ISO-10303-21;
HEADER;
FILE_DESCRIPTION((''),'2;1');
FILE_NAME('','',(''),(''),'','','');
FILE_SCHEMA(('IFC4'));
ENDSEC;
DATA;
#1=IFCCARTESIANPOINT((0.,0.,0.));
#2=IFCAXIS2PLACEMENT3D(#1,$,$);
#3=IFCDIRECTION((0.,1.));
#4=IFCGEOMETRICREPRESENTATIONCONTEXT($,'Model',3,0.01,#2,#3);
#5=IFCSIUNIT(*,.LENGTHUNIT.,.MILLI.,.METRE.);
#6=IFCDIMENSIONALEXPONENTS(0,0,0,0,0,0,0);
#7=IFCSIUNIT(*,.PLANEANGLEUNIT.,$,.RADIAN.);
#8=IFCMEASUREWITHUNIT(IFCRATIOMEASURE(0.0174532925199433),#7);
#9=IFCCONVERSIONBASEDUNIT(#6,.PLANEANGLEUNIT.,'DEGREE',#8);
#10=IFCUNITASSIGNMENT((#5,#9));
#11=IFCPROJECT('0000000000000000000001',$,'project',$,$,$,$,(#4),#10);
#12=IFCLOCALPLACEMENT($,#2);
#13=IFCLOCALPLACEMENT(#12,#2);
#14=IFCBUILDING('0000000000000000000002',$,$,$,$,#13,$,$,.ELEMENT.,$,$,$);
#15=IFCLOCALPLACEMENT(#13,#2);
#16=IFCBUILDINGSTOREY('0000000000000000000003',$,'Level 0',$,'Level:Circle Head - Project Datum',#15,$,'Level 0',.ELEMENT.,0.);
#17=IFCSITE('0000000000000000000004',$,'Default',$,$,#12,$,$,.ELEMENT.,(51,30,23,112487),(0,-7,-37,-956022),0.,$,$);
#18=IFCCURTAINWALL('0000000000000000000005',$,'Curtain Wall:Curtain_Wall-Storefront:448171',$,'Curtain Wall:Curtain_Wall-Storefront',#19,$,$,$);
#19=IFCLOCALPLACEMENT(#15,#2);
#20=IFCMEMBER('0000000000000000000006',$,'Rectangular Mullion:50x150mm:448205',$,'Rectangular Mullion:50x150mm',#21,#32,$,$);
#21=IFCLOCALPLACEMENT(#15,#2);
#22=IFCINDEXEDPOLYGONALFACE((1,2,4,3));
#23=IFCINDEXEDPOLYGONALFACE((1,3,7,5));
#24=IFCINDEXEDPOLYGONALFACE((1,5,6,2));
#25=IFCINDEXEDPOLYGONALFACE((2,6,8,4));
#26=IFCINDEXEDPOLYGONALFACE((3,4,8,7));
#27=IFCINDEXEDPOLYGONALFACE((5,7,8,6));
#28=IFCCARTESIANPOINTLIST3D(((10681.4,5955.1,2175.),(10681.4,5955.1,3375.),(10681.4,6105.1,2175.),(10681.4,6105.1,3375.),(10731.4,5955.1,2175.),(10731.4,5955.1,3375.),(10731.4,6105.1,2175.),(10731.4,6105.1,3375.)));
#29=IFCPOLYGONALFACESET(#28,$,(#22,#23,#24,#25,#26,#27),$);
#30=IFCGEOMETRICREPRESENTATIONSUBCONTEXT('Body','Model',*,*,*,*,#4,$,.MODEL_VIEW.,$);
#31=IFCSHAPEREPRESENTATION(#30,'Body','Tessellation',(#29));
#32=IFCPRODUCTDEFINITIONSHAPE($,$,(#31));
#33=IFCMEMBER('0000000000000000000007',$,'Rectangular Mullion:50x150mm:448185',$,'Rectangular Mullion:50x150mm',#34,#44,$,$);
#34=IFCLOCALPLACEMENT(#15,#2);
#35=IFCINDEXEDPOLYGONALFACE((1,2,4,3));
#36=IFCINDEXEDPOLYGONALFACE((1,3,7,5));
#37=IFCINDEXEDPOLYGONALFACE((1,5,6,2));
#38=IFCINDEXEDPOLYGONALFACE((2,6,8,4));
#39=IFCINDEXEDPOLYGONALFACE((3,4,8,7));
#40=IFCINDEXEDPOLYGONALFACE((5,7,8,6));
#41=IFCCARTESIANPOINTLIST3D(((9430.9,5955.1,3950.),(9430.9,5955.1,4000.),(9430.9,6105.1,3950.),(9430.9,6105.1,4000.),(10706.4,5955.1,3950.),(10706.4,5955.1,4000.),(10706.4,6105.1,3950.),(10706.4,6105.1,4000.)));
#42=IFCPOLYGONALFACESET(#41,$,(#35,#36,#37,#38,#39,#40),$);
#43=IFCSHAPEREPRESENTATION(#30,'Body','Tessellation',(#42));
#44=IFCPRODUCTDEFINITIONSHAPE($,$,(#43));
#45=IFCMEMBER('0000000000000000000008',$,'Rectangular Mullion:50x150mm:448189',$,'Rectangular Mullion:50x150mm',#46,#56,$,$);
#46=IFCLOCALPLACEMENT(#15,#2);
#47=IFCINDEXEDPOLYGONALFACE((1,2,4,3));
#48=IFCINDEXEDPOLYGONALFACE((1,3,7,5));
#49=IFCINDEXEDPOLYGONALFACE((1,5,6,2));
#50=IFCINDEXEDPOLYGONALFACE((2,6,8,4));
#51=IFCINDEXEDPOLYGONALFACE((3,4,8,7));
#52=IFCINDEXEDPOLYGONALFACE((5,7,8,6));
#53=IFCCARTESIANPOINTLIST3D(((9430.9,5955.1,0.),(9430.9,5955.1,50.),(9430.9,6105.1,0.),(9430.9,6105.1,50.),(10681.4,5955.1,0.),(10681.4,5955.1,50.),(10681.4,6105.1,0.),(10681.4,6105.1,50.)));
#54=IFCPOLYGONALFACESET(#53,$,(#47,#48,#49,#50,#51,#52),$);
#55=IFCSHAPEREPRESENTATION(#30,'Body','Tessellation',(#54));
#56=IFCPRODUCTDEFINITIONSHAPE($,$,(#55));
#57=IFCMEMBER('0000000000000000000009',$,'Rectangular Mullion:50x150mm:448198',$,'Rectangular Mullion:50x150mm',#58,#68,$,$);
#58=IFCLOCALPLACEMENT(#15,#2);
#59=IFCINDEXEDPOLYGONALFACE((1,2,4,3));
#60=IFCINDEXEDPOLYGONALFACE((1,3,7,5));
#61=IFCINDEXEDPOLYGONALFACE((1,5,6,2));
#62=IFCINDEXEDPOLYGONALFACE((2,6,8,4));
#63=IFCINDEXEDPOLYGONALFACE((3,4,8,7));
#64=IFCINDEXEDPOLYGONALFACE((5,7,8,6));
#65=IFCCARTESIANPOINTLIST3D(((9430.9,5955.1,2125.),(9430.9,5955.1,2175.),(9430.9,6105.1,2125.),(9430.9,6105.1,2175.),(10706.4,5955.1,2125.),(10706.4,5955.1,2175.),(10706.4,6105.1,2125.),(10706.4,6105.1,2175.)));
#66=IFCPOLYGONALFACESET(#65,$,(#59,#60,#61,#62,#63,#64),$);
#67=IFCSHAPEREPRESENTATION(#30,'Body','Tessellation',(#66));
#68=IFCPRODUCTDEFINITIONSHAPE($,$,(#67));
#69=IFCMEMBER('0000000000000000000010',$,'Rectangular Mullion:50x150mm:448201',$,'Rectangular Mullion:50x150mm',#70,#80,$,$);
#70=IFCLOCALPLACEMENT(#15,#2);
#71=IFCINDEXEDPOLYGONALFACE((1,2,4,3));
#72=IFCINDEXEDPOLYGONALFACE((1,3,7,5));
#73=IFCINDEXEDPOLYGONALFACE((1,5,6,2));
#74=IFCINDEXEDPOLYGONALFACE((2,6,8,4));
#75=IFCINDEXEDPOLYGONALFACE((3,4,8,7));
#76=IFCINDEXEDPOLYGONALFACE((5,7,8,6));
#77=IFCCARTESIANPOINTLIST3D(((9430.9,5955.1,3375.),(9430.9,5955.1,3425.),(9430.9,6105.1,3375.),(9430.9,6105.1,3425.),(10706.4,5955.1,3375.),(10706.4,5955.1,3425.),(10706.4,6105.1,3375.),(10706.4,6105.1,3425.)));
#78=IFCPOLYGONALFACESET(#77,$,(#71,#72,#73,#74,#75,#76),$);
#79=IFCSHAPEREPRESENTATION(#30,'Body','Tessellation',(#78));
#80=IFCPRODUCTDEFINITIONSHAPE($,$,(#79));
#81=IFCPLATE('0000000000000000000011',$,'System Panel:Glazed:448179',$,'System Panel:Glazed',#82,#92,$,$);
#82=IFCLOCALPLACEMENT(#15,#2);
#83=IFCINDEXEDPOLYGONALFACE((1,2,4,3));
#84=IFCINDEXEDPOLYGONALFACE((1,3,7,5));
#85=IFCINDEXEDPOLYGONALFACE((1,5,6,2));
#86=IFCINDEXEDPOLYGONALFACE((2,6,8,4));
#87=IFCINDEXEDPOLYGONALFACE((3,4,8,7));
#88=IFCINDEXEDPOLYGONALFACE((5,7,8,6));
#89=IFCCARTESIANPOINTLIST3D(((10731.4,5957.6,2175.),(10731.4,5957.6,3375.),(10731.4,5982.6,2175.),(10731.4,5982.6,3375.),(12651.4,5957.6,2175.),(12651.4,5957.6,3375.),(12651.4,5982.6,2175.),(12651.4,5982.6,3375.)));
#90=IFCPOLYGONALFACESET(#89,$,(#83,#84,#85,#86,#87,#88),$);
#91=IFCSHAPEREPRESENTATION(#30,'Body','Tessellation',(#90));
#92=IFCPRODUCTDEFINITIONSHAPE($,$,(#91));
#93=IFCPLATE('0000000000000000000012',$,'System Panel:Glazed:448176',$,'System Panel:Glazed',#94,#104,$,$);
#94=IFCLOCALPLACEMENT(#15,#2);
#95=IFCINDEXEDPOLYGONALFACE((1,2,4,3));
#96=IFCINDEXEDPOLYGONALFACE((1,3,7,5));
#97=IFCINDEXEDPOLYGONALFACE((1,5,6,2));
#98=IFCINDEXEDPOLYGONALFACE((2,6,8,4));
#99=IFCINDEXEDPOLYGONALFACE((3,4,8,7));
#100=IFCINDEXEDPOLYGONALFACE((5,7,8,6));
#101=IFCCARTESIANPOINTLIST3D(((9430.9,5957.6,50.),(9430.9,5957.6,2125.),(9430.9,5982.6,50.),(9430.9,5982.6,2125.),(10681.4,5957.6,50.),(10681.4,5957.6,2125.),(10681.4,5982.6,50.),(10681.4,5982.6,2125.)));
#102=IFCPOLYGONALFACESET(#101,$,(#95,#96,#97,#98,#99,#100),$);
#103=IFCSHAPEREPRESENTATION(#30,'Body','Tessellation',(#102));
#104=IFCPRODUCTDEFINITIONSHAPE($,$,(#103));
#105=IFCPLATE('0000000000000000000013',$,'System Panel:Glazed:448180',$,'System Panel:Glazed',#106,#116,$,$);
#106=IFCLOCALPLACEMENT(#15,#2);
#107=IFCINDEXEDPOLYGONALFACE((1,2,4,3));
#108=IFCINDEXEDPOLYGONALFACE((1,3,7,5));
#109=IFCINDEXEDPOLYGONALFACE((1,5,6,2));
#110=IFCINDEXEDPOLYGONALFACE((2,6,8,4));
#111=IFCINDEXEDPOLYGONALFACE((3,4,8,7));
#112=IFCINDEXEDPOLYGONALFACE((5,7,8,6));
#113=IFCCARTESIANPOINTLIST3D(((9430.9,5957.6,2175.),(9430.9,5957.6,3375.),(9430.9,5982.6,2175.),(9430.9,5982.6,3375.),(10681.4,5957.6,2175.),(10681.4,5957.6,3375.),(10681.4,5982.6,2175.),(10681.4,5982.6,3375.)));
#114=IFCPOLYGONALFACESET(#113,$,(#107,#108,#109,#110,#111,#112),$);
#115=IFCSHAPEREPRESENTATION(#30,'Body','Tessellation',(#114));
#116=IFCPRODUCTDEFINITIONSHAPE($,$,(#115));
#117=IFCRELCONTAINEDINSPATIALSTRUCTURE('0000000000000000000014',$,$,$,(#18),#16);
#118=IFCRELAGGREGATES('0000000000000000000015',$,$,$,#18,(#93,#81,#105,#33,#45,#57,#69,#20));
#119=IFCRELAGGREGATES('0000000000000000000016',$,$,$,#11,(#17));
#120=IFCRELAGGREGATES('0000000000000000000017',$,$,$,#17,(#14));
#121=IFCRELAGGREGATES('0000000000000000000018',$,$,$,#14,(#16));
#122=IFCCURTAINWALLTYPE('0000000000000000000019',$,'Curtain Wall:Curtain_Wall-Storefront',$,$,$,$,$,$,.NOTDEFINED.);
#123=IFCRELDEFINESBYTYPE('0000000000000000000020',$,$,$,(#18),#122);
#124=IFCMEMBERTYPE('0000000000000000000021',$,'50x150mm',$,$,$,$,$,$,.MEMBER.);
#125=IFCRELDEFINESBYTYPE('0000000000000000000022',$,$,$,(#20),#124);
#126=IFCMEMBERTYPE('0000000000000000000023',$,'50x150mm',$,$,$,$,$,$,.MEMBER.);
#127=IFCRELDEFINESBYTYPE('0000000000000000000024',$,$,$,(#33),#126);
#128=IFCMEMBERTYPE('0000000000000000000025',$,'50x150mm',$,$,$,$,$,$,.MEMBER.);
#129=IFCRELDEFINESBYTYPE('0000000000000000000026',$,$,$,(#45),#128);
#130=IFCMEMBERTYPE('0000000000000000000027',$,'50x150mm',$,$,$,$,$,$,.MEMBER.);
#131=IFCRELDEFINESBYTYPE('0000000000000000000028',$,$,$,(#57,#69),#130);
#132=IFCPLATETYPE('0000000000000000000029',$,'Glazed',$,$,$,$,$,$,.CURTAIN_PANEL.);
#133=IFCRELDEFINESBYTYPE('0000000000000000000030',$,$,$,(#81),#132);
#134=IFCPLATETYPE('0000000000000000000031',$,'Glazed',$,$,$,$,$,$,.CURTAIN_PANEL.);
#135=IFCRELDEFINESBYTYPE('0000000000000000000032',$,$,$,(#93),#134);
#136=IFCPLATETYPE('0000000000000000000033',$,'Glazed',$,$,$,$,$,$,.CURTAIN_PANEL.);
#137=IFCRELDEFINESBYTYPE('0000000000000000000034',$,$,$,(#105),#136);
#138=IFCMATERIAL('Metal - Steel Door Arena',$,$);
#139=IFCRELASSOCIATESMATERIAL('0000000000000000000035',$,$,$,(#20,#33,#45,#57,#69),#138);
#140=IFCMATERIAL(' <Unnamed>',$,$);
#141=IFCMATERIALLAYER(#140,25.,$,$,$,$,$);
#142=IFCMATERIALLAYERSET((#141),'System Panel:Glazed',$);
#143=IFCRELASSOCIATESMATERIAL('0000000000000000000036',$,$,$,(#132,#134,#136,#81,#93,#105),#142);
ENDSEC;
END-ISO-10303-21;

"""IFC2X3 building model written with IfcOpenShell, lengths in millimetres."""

from ifc_helpers import new_model, entity, si_unit, converted_unit, direction, frame, origin, origin_2d_with_axis, place, context, subcontext, project, spatial, rectangle, extrude, source, transform, mapped, material, layer, layer_set, layer_usage, type_object, type_shapes, element, aggregate, save


model = new_model("IFC2X3")

# Units and contexts
model_context = context("Model", 3, precision=0.01, world=origin(), true_north=direction((0.0, 1.0)))
body_context = subcontext(model_context, "Body", "Model", "MODEL_VIEW")
ifc_project = project(units=[si_unit("LENGTHUNIT", "METRE", prefix="MILLI"), converted_unit("PLANEANGLEUNIT", "DEGREE", entity("IfcRatioMeasure", 0.0174532925199433), si_unit("PLANEANGLEUNIT", "RADIAN"), dimensions=[0, 0, 0, 0, 0, 0, 0])], contexts=[model_context])

# Site, building, storey
site_placement = place(None, origin())
site = spatial("IfcSite", under=ifc_project, at=site_placement, Name="Default", CompositionType="ELEMENT", RefLatitude=(51, 30, 23, 112487), RefLongitude=(0, -7, -37, -956022), RefElevation=0.0)
building_placement = place(site_placement, origin())
building = spatial("IfcBuilding", under=site, at=building_placement, CompositionType="ELEMENT")
storey_placement = place(building_placement, origin())
storey = spatial("IfcBuildingStorey", under=building, at=storey_placement, Name="Level 0", ObjectType="Level:Circle Head - Project Datum", LongName="Level 0", CompositionType="ELEMENT", Elevation=0.0)

# Curtain wall
curtain_wall_type = type_object("IfcCurtainWallType", Name="Curtain Wall:Curtain_Wall-Storefront", PredefinedType="NOTDEFINED")
curtain_wall_1_placement = place(storey_placement, origin())
curtain_wall_1 = element("IfcCurtainWall", 1, at=curtain_wall_1_placement, inside=storey, type_object=curtain_wall_type, Name="Curtain Wall:Curtain_Wall-Storefront:448171", ObjectType="Curtain Wall:Curtain_Wall-Storefront")
ifc_material_1 = material(Name="Metal - Steel Door Arena")

# Members
member_type_1 = type_object("IfcMemberType", Name="50x150mm", PredefinedType="MEMBER")
shared_shape_1 = source(origin(), body_context, "Body", "SweptSolid", [
    extrude(rectangle(XDim=150.0, YDim=50.0, at=origin_2d_with_axis()), frame((0.0, 0.0, -1200.0), z_axis=(0.0, 0.0, 1.0), x_axis=(0.0, -1.0, 0.0)), (0.0, 0.0, 1.0), 1200.0),
])
type_shapes(member_type_1, [shared_shape_1])
member_1_placement = place(storey_placement, frame((10706.4, 6030.1, 2175.0), z_axis=(0.0, 0.0, -1.0), x_axis=(-1.0, 0.0, 0.0)))
member_1 = element("IfcMember", 2, at=member_1_placement, type_object=member_type_1, material=ifc_material_1, Name="Rectangular Mullion:50x150mm:448205", ObjectType="Rectangular Mullion:50x150mm", context=body_context, shape_type="MappedRepresentation", body=[
    mapped(shared_shape_1, transform((0.0, 0.0, 0.0), scale=1.0)),
])
member_type_2 = type_object("IfcMemberType", Name="50x150mm", PredefinedType="MEMBER")
shared_shape_2 = source(origin(), body_context, "Body", "SweptSolid", [
    extrude(rectangle(XDim=150.0, YDim=50.0, at=origin_2d_with_axis()), frame((-25.0, 0.0, -1275.5), z_axis=(0.0, 0.0, 1.0), x_axis=(0.0, -1.0, 0.0)), (0.0, 0.0, 1.0), 1275.5),
])
type_shapes(member_type_2, [shared_shape_2])
member_2_placement = place(storey_placement, frame((9430.9, 6030.1, 4000.0), z_axis=(-1.0, 0.0, 0.0), x_axis=(0.0, 0.0, 1.0)))
member_2 = element("IfcMember", 3, at=member_2_placement, type_object=member_type_2, material=ifc_material_1, Name="Rectangular Mullion:50x150mm:448185", ObjectType="Rectangular Mullion:50x150mm", context=body_context, shape_type="MappedRepresentation", body=[
    mapped(shared_shape_2, transform((0.0, 0.0, 0.0), scale=1.0)),
])
member_type_3 = type_object("IfcMemberType", Name="50x150mm", PredefinedType="MEMBER")
shared_shape_3 = source(origin(), body_context, "Body", "SweptSolid", [
    extrude(rectangle(XDim=150.0, YDim=50.0, at=origin_2d_with_axis()), frame((-25.0, 0.0, -1250.5), z_axis=(0.0, 0.0, 1.0), x_axis=(0.0, -1.0, 0.0)), (0.0, 0.0, 1.0), 1250.5),
])
type_shapes(member_type_3, [shared_shape_3])
member_3_placement = place(storey_placement, frame((10681.4, 6030.1, 0.0), z_axis=(1.0, 0.0, 0.0), x_axis=(0.0, 0.0, -1.0)))
member_3 = element("IfcMember", 4, at=member_3_placement, type_object=member_type_3, material=ifc_material_1, Name="Rectangular Mullion:50x150mm:448189", ObjectType="Rectangular Mullion:50x150mm", context=body_context, shape_type="MappedRepresentation", body=[
    mapped(shared_shape_3, transform((0.0, 0.0, 0.0), scale=1.0)),
])
member_type_4 = type_object("IfcMemberType", Name="50x150mm", PredefinedType="MEMBER")
shared_shape_4 = source(origin(), body_context, "Body", "SweptSolid", [
    extrude(rectangle(XDim=150.0, YDim=50.0, at=origin_2d_with_axis()), frame((0.0, 0.0, -1275.5), z_axis=(0.0, 0.0, 1.0), x_axis=(0.0, -1.0, 0.0)), (0.0, 0.0, 1.0), 1275.5),
])
type_shapes(member_type_4, [shared_shape_4])
member_4_placement = place(storey_placement, frame((9430.9, 6030.1, 2150.0), z_axis=(-1.0, 0.0, 0.0), x_axis=(0.0, 0.0, 1.0)))
member_4 = element("IfcMember", 5, at=member_4_placement, type_object=member_type_4, material=ifc_material_1, Name="Rectangular Mullion:50x150mm:448198", ObjectType="Rectangular Mullion:50x150mm", context=body_context, shape_type="MappedRepresentation", body=[
    mapped(shared_shape_4, transform((0.0, 0.0, 0.0), scale=1.0)),
])
member_5_placement = place(storey_placement, frame((9430.9, 6030.1, 3400.0), z_axis=(-1.0, 0.0, 0.0), x_axis=(0.0, 0.0, 1.0)))
member_5 = element("IfcMember", 6, at=member_5_placement, type_object=member_type_4, material=ifc_material_1, Name="Rectangular Mullion:50x150mm:448201", ObjectType="Rectangular Mullion:50x150mm", context=body_context, shape_type="MappedRepresentation", body=[
    mapped(shared_shape_4, transform((0.0, 0.0, 0.0), scale=1.0)),
])

# Plates
ifc_material_2 = material(Name=" <Unnamed>")
ifc_layer_1 = layer(ifc_material_2, 25.0)
ifc_layer_set_1 = layer_set([ifc_layer_1], Name="System Panel:Glazed")
ifc_layer_usage_1 = layer_usage(ifc_layer_set_1, "AXIS3", "POSITIVE", 0.2)
plate_type_1 = type_object("IfcPlateType", Name="Glazed", PredefinedType="CURTAIN_PANEL", material=ifc_layer_set_1)
shared_shape_5 = source(origin(), body_context, "Body", "SweptSolid", [
    extrude(rectangle(XDim=25.0, YDim=1920.0, at=origin_2d_with_axis()), frame((0.0, 60.0, 0.0), z_axis=(0.0, 0.0, 1.0), x_axis=(0.0, 1.0, 0.0)), (0.0, 0.0, 1.0), 1200.0),
])
type_shapes(plate_type_1, [shared_shape_5])
plate_1_placement = place(curtain_wall_1_placement, frame((11691.4, 6030.1, 2175.0), z_axis=(0.0, 0.0, 1.0), x_axis=(-1.0, 0.0, 0.0)))
plate_1 = element("IfcPlate", 7, at=plate_1_placement, type_object=plate_type_1, material=ifc_layer_usage_1, Name="System Panel:Glazed:448179", ObjectType="System Panel:Glazed", context=body_context, shape_type="MappedRepresentation", body=[
    mapped(shared_shape_5, transform((0.0, 0.0, 0.0), scale=1.0)),
])
ifc_layer_usage_2 = layer_usage(ifc_layer_set_1, "AXIS3", "POSITIVE", 0.2)
plate_type_2 = type_object("IfcPlateType", Name="Glazed", PredefinedType="CURTAIN_PANEL", material=ifc_layer_set_1)
shared_shape_6 = source(origin(), body_context, "Body", "SweptSolid", [
    extrude(rectangle(XDim=25.0, YDim=1250.5, at=origin_2d_with_axis()), frame((0.0, 60.0, 0.0), z_axis=(0.0, 0.0, 1.0), x_axis=(0.0, 1.0, 0.0)), (0.0, 0.0, 1.0), 2075.0),
])
type_shapes(plate_type_2, [shared_shape_6])
plate_2_placement = place(curtain_wall_1_placement, frame((10056.1, 6030.1, 50.0), z_axis=(0.0, 0.0, 1.0), x_axis=(-1.0, 0.0, 0.0)))
plate_2 = element("IfcPlate", 8, at=plate_2_placement, type_object=plate_type_2, material=ifc_layer_usage_2, Name="System Panel:Glazed:448176", ObjectType="System Panel:Glazed", context=body_context, shape_type="MappedRepresentation", body=[
    mapped(shared_shape_6, transform((0.0, 0.0, 0.0), scale=1.0)),
])
ifc_layer_usage_3 = layer_usage(ifc_layer_set_1, "AXIS3", "POSITIVE", 0.2)
plate_type_3 = type_object("IfcPlateType", Name="Glazed", PredefinedType="CURTAIN_PANEL", material=ifc_layer_set_1)
shared_shape_7 = source(origin(), body_context, "Body", "SweptSolid", [
    extrude(rectangle(XDim=25.0, YDim=1250.5, at=origin_2d_with_axis()), frame((0.0, 60.0, 0.0), z_axis=(0.0, 0.0, 1.0), x_axis=(0.0, 1.0, 0.0)), (0.0, 0.0, 1.0), 1200.0),
])
type_shapes(plate_type_3, [shared_shape_7])
plate_3_placement = place(curtain_wall_1_placement, frame((10056.1, 6030.1, 2175.0), z_axis=(0.0, 0.0, 1.0), x_axis=(-1.0, 0.0, 0.0)))
plate_3 = element("IfcPlate", 9, at=plate_3_placement, type_object=plate_type_3, material=ifc_layer_usage_3, Name="System Panel:Glazed:448180", ObjectType="System Panel:Glazed", context=body_context, shape_type="MappedRepresentation", body=[
    mapped(shared_shape_7, transform((0.0, 0.0, 0.0), scale=1.0)),
])
aggregate(curtain_wall_1, [plate_2, plate_1, plate_3, member_2, member_3, member_4, member_5, member_1])

save(model, "model.ifc")
